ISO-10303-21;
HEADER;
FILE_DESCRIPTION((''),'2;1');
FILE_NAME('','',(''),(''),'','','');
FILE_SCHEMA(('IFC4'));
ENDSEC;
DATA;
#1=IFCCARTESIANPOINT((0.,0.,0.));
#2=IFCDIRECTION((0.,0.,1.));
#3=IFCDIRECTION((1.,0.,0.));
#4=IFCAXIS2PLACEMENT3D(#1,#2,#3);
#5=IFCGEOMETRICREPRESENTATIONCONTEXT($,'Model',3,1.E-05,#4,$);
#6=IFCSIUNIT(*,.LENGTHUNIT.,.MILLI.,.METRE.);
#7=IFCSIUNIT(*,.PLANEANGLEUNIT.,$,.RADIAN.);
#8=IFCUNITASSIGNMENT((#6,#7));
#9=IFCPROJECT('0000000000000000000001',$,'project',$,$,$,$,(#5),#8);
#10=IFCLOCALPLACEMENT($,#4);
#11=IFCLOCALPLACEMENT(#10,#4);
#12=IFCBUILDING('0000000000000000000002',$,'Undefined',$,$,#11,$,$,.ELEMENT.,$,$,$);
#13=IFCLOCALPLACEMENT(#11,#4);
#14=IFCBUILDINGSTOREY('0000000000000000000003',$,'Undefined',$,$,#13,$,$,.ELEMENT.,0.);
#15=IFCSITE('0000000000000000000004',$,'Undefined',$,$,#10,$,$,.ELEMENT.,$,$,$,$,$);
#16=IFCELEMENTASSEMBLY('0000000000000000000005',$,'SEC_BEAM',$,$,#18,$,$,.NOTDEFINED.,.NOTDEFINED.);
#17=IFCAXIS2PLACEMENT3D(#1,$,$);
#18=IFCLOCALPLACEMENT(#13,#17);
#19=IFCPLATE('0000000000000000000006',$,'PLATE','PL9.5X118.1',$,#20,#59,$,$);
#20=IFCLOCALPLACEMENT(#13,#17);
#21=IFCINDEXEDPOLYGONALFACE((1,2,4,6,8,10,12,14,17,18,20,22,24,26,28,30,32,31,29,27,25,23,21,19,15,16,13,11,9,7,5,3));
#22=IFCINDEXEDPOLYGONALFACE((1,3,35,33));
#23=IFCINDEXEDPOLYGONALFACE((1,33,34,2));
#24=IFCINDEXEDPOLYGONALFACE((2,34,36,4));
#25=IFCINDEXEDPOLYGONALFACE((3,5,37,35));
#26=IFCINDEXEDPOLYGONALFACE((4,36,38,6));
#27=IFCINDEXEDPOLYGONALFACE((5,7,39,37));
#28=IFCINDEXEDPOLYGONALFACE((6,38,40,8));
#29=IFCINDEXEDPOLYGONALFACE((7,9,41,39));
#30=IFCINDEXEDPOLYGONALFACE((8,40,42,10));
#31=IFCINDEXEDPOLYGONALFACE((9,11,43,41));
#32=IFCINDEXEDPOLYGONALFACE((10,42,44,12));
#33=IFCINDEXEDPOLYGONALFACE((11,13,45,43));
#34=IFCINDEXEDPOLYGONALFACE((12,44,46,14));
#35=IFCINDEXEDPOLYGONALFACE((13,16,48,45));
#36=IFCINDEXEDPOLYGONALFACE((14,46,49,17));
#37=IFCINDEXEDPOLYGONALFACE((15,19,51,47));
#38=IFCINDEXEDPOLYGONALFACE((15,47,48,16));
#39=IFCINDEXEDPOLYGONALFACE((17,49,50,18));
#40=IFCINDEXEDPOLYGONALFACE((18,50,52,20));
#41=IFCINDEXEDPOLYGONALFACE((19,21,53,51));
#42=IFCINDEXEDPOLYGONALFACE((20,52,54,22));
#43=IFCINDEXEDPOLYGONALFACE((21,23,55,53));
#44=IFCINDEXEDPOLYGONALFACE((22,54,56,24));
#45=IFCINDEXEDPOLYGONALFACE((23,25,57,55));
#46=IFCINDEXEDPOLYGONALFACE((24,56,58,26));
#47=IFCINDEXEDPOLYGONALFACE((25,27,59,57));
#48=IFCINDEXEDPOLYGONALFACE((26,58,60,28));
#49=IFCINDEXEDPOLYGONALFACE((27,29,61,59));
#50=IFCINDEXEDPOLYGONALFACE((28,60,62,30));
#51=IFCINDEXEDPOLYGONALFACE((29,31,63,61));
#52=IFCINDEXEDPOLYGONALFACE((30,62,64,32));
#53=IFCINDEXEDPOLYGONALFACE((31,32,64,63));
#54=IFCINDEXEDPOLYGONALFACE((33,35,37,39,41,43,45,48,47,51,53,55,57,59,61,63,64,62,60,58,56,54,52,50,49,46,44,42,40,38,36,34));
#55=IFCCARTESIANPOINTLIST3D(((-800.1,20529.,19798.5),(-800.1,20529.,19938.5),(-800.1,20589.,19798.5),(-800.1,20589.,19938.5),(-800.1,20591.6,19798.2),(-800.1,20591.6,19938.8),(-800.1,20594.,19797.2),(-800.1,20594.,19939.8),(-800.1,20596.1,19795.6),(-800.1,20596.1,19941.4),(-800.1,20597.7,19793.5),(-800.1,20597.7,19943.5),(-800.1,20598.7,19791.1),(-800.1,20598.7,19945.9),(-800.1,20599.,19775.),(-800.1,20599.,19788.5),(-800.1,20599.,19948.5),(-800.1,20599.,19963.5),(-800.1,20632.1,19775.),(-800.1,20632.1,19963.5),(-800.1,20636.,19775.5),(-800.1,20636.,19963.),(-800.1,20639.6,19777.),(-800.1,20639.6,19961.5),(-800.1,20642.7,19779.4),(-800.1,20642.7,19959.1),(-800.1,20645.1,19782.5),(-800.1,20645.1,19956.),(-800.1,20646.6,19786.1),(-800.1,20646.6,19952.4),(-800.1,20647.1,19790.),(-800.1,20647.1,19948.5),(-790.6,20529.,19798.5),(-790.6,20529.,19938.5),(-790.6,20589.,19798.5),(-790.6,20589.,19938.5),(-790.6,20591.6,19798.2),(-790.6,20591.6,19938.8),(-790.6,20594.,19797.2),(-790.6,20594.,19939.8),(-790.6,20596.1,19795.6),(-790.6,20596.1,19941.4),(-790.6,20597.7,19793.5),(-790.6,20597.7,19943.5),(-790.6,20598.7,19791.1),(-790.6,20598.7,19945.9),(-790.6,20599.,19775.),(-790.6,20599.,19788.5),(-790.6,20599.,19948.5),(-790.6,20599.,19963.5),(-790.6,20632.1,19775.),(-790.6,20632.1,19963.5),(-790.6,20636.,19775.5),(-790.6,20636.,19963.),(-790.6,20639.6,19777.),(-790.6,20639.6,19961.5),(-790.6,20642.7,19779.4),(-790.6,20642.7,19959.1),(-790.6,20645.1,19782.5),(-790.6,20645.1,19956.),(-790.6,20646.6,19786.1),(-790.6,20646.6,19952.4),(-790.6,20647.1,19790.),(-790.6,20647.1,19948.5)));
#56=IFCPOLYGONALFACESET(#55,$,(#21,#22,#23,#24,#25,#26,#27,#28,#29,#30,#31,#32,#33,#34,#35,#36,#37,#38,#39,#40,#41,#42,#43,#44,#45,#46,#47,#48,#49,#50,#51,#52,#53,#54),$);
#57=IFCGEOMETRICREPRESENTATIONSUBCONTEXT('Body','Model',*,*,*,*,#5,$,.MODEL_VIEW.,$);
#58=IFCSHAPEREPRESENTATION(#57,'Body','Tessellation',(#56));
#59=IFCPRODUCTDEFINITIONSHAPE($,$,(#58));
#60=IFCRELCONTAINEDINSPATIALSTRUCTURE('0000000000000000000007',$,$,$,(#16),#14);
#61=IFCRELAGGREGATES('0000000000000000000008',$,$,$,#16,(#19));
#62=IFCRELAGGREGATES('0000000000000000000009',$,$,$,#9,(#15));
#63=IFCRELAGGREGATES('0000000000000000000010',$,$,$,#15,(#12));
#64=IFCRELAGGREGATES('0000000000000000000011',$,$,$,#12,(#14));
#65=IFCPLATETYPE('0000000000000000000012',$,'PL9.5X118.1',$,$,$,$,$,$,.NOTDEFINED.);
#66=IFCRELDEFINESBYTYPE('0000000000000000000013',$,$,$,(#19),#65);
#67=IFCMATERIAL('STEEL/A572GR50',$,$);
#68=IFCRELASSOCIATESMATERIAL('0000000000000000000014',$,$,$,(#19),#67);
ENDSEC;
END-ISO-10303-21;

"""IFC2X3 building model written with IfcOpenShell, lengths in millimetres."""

from ifc_helpers import new_model, si_unit, frame, frame_2d, origin_with_axes, place, context, subcontext, project, spatial, polyline, circle_curve, parameter, trimmed, segment, composite_curve, outline, extrude, material, type_object, element, aggregate, save


model = new_model("IFC2X3")

# Units and contexts
model_context = context("Model", 3, precision=1e-05, world=origin_with_axes())
body_context = subcontext(model_context, "Body", "Model", "MODEL_VIEW")
ifc_project = project(units=[si_unit("LENGTHUNIT", "METRE", prefix="MILLI"), si_unit("PLANEANGLEUNIT", "RADIAN")], contexts=[model_context])

# Site, building, storey
site_placement = place(None, origin_with_axes())
site = spatial("IfcSite", under=ifc_project, at=site_placement, Name="Undefined", CompositionType="ELEMENT")
building_placement = place(site_placement, origin_with_axes())
building = spatial("IfcBuilding", under=site, at=building_placement, Name="Undefined", CompositionType="ELEMENT")
storey_placement = place(building_placement, origin_with_axes())
storey = spatial("IfcBuildingStorey", under=building, at=storey_placement, Name="Undefined", CompositionType="ELEMENT", Elevation=0.0)

# Shared definitions
ifc_material_1 = material(Name="STEEL/A572GR50")

# Element assembly
assembly_1_placement = place(storey_placement, origin_with_axes())
assembly_1 = element("IfcElementAssembly", 1, at=assembly_1_placement, inside=storey, Name="SEC_BEAM", AssemblyPlace="NOTDEFINED", PredefinedType="NOTDEFINED")

# Plate
plate_type_1 = type_object("IfcPlateType", Name="PL9.5X118.1", PredefinedType="NOTDEFINED")
plate_1_placement = place(assembly_1_placement, frame((-795.3, 20647.1, 19963.5), z_axis=(-1.0, 0.0, 0.0), x_axis=(0.0, 0.0, -1.0)))
plate_1 = element("IfcPlate", 2, at=plate_1_placement, type_object=plate_type_1, material=ifc_material_1, Name="PLATE", Description="PL9.5X118.1", context=body_context, shape_type="SweptSolid", body=[
    extrude(outline(composite_curve([segment(trimmed(circle_curve(frame_2d((15.0, 15.0), x_axis=(-1.0, 0.0)), 15.0), [parameter(0.0)], [parameter(1.570796)], True, "PARAMETER"), True, "CONTINUOUS"), segment(polyline([(15.0, 0.0), (173.5, 0.0)]), True, "CONTINUOUS"), segment(trimmed(circle_curve(frame_2d((173.5, 15.0), x_axis=(0.0, -1.0)), 15.0), [parameter(0.0)], [parameter(1.570796)], True, "PARAMETER"), True, "CONTINUOUS"), segment(polyline([(188.5, 15.0), (188.5, 48.1), (175.0, 48.1)]), True, "CONTINUOUS"), segment(trimmed(circle_curve(frame_2d((175.0, 58.1), x_axis=(0.0, -1.0)), 10.0), [parameter(0.0)], [parameter(4.712389)], False, "PARAMETER"), True, "CONTINUOUS"), segment(polyline([(165.0, 58.1), (165.0, 118.1), (25.0, 118.1), (25.0, 58.1)]), True, "CONTINUOUS"), segment(trimmed(circle_curve(frame_2d((15.0, 58.1), x_axis=(1.0, 0.0)), 10.0), [parameter(0.0)], [parameter(4.712389)], False, "PARAMETER"), True, "CONTINUOUS"), segment(polyline([(15.0, 48.1), (0.0, 48.1), (0.0, 15.0)]), True, "CONTINUOUS")], self_intersect=True)), frame((0.0, 0.0, -4.8), z_axis=(0.0, 0.0, 1.0), x_axis=(1.0, 0.0, 0.0)), (0.0, 0.0, 1.0), 9.5),
])

aggregate(assembly_1, [plate_1])

save(model, "model.ifc")
